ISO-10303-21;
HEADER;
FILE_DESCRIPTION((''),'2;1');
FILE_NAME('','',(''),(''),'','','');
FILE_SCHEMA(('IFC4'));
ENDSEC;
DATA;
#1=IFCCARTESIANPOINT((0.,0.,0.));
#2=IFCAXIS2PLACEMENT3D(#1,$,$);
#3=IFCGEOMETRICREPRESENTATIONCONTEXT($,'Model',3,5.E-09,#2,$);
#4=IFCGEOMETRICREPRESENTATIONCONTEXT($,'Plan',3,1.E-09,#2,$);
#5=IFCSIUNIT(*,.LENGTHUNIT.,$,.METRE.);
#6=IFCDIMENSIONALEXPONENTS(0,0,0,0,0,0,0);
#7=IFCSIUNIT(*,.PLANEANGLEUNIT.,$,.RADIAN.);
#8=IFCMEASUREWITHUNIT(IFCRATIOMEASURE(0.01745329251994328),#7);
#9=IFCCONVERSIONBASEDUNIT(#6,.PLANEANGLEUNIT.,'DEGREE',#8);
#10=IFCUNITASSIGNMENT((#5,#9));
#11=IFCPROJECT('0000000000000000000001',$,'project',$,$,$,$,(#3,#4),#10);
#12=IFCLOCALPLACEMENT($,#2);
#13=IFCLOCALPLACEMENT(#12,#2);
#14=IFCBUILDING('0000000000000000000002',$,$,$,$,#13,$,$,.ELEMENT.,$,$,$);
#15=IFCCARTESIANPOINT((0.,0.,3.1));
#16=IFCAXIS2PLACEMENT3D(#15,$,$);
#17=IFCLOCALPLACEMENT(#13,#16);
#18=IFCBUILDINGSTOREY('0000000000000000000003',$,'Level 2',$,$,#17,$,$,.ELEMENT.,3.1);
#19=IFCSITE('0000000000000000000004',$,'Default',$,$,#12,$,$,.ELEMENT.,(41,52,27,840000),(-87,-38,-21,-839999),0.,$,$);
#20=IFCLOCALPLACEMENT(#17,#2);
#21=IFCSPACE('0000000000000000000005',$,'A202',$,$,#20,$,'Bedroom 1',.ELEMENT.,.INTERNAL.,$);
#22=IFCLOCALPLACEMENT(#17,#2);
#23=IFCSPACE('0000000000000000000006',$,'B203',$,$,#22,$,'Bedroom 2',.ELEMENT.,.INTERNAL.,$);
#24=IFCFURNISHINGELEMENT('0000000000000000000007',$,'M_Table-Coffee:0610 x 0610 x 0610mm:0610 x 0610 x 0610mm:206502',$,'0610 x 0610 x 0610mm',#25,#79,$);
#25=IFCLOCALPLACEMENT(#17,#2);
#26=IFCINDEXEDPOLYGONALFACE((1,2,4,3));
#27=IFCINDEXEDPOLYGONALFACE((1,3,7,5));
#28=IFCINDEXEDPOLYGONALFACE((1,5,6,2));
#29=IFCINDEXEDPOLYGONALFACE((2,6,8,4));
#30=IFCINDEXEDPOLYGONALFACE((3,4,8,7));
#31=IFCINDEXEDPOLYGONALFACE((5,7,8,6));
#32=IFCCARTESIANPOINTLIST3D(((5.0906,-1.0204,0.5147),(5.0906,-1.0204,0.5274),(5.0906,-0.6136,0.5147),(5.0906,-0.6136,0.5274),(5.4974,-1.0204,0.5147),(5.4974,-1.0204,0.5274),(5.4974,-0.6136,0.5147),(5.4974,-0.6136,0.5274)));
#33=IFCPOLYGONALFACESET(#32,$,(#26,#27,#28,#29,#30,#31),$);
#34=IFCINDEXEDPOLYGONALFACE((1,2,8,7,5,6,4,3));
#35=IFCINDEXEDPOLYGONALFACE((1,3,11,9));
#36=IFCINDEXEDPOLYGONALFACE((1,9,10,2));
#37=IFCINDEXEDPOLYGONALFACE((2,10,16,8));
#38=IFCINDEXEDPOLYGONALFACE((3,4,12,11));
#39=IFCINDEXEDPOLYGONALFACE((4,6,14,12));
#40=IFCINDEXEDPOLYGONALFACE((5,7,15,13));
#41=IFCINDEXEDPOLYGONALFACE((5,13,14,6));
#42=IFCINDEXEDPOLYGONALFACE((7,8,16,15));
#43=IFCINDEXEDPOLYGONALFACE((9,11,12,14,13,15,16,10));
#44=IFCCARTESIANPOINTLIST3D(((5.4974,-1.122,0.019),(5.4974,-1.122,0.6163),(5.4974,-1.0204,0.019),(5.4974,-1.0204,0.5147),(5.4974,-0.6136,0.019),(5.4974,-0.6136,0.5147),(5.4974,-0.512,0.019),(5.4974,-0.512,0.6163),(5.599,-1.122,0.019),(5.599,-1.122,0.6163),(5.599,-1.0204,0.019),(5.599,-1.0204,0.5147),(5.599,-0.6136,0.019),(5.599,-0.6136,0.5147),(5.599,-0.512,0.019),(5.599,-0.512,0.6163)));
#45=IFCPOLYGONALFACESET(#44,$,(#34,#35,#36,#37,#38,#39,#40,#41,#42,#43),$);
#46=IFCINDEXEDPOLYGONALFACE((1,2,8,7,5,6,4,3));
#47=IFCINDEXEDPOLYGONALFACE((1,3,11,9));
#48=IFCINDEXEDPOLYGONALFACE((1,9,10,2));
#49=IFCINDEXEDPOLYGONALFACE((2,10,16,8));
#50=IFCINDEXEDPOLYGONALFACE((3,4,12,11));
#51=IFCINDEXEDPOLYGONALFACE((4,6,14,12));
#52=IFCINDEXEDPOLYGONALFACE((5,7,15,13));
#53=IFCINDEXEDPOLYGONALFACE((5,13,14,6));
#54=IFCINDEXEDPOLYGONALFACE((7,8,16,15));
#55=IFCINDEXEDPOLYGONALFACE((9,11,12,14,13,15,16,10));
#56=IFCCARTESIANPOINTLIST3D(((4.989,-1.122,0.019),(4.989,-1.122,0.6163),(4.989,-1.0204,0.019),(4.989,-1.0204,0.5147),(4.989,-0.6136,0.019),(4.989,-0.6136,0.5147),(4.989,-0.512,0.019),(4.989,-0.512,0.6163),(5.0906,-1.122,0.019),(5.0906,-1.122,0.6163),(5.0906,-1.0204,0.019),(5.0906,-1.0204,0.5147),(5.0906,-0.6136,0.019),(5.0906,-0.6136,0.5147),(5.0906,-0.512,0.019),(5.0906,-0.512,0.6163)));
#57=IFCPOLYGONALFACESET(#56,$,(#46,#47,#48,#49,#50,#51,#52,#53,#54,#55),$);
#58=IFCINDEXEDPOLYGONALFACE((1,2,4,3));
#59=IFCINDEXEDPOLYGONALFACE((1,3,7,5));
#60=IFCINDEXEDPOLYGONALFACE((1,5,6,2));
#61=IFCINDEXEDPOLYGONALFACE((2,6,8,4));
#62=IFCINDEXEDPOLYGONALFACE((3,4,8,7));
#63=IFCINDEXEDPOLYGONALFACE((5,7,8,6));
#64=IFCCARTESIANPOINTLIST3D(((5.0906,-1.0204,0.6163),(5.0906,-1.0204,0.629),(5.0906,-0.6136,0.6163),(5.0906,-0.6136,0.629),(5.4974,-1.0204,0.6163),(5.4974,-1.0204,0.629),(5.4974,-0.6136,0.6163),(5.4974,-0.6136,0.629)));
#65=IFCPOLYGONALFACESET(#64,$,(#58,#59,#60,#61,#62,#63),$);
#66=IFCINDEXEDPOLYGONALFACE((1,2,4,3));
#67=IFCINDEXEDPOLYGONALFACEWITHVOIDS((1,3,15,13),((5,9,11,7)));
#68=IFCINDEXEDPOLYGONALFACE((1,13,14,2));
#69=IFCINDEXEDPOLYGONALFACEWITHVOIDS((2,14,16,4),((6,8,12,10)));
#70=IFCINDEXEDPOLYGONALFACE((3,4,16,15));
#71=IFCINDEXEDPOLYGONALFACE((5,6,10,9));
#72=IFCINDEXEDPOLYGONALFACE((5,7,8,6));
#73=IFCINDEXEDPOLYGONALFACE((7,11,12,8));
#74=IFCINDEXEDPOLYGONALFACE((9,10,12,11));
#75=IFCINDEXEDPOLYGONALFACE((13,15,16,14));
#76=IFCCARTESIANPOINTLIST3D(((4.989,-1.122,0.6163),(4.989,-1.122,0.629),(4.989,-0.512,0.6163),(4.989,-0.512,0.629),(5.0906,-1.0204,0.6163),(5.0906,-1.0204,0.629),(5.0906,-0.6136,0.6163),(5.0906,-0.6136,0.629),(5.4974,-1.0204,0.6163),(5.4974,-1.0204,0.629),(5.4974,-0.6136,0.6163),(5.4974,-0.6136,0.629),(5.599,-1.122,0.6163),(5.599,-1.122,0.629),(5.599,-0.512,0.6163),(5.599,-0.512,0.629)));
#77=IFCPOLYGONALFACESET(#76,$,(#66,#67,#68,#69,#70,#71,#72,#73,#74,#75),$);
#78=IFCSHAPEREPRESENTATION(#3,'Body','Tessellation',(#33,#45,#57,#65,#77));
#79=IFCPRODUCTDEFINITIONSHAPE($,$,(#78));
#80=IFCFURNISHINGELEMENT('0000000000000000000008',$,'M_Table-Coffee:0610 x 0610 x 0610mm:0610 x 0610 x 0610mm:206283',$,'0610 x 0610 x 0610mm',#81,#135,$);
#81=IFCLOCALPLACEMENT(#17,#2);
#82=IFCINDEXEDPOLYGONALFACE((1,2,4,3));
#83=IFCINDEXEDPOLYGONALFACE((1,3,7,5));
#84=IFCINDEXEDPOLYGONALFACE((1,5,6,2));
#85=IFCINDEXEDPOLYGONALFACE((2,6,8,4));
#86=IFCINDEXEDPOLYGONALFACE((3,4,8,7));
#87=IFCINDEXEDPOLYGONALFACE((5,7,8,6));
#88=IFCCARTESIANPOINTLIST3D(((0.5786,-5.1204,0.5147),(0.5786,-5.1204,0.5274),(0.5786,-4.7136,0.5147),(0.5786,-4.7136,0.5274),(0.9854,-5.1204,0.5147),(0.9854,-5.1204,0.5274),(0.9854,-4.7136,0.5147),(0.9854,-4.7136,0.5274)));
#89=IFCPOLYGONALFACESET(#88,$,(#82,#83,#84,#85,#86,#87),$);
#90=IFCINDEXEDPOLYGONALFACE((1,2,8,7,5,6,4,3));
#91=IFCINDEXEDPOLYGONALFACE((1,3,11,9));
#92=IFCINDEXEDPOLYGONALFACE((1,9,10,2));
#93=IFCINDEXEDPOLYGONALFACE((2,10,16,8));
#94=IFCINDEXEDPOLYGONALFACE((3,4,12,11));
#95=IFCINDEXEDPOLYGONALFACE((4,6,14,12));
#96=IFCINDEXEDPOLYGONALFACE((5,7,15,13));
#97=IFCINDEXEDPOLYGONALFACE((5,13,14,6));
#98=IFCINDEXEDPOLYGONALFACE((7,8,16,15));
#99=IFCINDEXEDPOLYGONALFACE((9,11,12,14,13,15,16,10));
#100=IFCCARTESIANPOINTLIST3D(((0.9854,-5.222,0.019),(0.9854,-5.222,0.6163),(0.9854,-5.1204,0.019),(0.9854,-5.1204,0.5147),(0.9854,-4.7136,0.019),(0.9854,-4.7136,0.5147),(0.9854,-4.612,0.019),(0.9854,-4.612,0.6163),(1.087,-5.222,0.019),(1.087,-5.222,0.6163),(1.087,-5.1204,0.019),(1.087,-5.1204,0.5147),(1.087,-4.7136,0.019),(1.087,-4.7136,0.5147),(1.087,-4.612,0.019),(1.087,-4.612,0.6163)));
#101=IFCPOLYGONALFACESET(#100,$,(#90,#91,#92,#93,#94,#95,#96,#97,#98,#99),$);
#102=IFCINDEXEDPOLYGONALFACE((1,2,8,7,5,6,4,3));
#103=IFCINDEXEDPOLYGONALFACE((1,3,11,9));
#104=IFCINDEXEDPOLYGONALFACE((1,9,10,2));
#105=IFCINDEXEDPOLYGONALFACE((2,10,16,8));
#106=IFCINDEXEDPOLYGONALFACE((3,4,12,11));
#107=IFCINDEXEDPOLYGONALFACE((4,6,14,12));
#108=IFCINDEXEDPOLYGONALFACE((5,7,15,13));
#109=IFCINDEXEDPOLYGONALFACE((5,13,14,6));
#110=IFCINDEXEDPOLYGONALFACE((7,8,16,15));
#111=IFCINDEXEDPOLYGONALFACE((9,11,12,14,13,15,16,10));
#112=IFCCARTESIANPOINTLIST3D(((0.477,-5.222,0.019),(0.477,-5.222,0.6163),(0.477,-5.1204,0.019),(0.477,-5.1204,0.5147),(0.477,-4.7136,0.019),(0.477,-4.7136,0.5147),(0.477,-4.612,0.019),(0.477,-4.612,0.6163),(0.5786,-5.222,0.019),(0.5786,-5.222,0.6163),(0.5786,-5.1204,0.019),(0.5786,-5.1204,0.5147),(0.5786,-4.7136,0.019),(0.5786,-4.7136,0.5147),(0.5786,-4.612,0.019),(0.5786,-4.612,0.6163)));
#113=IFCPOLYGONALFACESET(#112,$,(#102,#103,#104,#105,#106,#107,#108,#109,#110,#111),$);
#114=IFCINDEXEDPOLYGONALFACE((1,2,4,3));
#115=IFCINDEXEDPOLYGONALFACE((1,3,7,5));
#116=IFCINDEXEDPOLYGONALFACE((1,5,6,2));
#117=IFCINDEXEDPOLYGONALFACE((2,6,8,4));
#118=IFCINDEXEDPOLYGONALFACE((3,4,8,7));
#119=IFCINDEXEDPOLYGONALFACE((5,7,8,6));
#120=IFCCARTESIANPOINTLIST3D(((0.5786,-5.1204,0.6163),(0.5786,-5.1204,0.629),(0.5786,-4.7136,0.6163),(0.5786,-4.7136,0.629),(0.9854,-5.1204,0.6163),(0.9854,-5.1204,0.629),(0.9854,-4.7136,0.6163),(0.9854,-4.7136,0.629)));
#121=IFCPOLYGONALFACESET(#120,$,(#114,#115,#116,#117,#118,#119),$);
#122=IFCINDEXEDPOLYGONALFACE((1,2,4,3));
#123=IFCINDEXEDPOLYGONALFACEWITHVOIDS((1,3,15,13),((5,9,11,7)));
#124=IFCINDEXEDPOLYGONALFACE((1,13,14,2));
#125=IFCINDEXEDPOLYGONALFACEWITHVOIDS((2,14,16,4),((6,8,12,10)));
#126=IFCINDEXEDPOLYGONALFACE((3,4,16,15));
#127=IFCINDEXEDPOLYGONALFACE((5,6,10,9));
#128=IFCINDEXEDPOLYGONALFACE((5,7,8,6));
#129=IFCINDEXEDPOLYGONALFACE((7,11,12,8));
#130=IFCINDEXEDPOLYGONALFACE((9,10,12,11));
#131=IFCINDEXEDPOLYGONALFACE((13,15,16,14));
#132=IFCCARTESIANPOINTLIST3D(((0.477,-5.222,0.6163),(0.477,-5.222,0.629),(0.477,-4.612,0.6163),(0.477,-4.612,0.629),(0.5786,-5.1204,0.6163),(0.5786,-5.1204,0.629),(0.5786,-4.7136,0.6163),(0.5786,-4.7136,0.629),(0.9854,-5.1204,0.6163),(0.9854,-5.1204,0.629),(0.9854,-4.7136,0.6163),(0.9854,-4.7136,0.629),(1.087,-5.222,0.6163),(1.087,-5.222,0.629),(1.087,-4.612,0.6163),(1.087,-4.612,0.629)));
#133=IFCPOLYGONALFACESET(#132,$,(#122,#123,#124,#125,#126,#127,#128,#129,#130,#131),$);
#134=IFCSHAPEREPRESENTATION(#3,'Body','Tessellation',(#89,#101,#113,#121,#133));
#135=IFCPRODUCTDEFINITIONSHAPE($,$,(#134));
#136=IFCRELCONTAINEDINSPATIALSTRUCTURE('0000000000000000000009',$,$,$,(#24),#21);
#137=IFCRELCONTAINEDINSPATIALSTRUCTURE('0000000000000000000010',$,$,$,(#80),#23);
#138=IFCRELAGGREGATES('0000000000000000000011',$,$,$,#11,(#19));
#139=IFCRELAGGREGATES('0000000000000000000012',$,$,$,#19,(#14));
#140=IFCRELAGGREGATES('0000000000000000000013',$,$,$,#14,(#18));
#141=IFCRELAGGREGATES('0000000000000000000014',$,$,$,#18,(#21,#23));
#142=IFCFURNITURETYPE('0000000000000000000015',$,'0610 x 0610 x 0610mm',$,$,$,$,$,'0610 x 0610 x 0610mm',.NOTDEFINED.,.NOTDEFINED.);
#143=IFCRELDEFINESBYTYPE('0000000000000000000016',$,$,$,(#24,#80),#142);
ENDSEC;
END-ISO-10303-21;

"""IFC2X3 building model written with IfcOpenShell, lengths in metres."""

from ifc_helpers import new_model, entity, si_unit, converted_unit, frame, origin, origin_2d_with_axis, place, context, project, spatial, polyline, rectangle, outline, extrude, source, transform, mapped, type_object, type_shapes, element, save


model = new_model("IFC2X3")

# Units and contexts
model_context = context("Model", 3, precision=5e-09, world=origin())
plan_context = context("Plan", 3, precision=1e-09, world=origin())
ifc_project = project(units=[si_unit("LENGTHUNIT", "METRE"), converted_unit("PLANEANGLEUNIT", "DEGREE", entity("IfcRatioMeasure", 0.01745329251994328), si_unit("PLANEANGLEUNIT", "RADIAN"), dimensions=[0, 0, 0, 0, 0, 0, 0])], contexts=[model_context, plan_context])

# Site, building, storey
site_placement = place(None, origin())
site = spatial("IfcSite", under=ifc_project, at=site_placement, Name="Default", CompositionType="ELEMENT", RefLatitude=(41, 52, 27, 840000), RefLongitude=(-87, -38, -21, -839999), RefElevation=0.0)
building_placement = place(site_placement, origin())
building = spatial("IfcBuilding", under=site, at=building_placement, CompositionType="ELEMENT")
storey_placement = place(building_placement, frame((0.0, 0.0, 3.1)))
storey = spatial("IfcBuildingStorey", under=building, at=storey_placement, Name="Level 2", CompositionType="ELEMENT", Elevation=3.1)

# Shared definitions
space_1_placement = place(storey_placement, origin())
space_1 = spatial("IfcSpace", under=storey, at=space_1_placement, Name="A202", LongName="Bedroom 1", CompositionType="ELEMENT", InteriorOrExteriorSpace="INTERNAL")

# Furnishing element
furniture_type = type_object("IfcFurnitureType", Name="0610 x 0610 x 0610mm", ElementType="0610 x 0610 x 0610mm", AssemblyPlace="NOTDEFINED")
shared_shape_1 = source(origin(), model_context, "Body", "SweptSolid", [
    extrude(rectangle(XDim=0.4068, YDim=0.4068, at=origin_2d_with_axis()), frame((0.0183, 0.0952, 0.4957), z_axis=(0.0, 0.0, 1.0), x_axis=(-1.0, 0.0, 0.0)), (0.0, 0.0, 1.0), 0.0127),
    extrude(outline(polyline([(-0.2732, -0.305), (0.324, -0.305), (0.324, 0.305), (-0.2732, 0.305), (-0.2732, 0.2034), (0.2225, 0.2034), (0.2225, -0.2034), (-0.2732, -0.2034), (-0.2732, -0.305)])), frame((0.2217, 0.0952, 0.2732), z_axis=(1.0, 0.0, 0.0), x_axis=(0.0, 0.0, 1.0)), (0.0, 0.0, 1.0), 0.1016),
    extrude(outline(polyline([(-0.305, -0.3241), (0.305, -0.3241), (0.305, 0.2733), (0.2034, 0.2733), (0.2034, -0.2224), (-0.2034, -0.2224), (-0.2034, 0.2733), (-0.305, 0.2733), (-0.305, -0.3241)])), frame((-0.2867, 0.0952, 0.2733), z_axis=(1.0, 0.0, 0.0), x_axis=(0.0, -1.0, 0.0)), (0.0, 0.0, 1.0), 0.1016),
    extrude(rectangle(XDim=0.4068, YDim=0.4068, at=origin_2d_with_axis()), frame((0.0183, 0.0952, 0.5973), z_axis=(0.0, 0.0, 1.0), x_axis=(-1.0, 0.0, 0.0)), (0.0, 0.0, 1.0), 0.0127),
    extrude(outline(polyline([(-0.305, -0.305), (0.305, -0.305), (0.305, 0.305), (-0.305, 0.305), (-0.305, -0.305)]), holes=[polyline([(-0.2034, -0.2034), (-0.2034, 0.2034), (0.2034, 0.2034), (0.2034, -0.2034), (-0.2034, -0.2034)])]), frame((0.0183, 0.0952, 0.5973), z_axis=(0.0, 0.0, 1.0), x_axis=(-1.0, 0.0, 0.0)), (0.0, 0.0, 1.0), 0.0127),
])
type_shapes(furniture_type, [shared_shape_1])
furnishing_1_placement = place(space_1_placement, frame((5.2757, -0.9122, 0.019)))
element("IfcFurnishingElement", 1, at=furnishing_1_placement, inside=space_1, type_object=furniture_type, Name="M_Table-Coffee:0610 x 0610 x 0610mm:0610 x 0610 x 0610mm:206502", ObjectType="0610 x 0610 x 0610mm", context=model_context, shape_type="MappedRepresentation", body=[
    mapped(shared_shape_1, transform((0.0, 0.0, 0.0), scale=1.0)),
])

# Shared definitions
space_2_placement = place(storey_placement, origin())
space_2 = spatial("IfcSpace", under=storey, at=space_2_placement, Name="B203", LongName="Bedroom 2", CompositionType="ELEMENT", InteriorOrExteriorSpace="INTERNAL")

# Furnishing element
furnishing_2_placement = place(space_2_placement, frame((0.7637, -5.0122, 0.019)))
element("IfcFurnishingElement", 2, at=furnishing_2_placement, inside=space_2, type_object=furniture_type, Name="M_Table-Coffee:0610 x 0610 x 0610mm:0610 x 0610 x 0610mm:206283", ObjectType="0610 x 0610 x 0610mm", context=model_context, shape_type="MappedRepresentation", body=[
    mapped(shared_shape_1, transform((0.0, 0.0, 0.0), scale=1.0)),
])

save(model, "model.ifc")
